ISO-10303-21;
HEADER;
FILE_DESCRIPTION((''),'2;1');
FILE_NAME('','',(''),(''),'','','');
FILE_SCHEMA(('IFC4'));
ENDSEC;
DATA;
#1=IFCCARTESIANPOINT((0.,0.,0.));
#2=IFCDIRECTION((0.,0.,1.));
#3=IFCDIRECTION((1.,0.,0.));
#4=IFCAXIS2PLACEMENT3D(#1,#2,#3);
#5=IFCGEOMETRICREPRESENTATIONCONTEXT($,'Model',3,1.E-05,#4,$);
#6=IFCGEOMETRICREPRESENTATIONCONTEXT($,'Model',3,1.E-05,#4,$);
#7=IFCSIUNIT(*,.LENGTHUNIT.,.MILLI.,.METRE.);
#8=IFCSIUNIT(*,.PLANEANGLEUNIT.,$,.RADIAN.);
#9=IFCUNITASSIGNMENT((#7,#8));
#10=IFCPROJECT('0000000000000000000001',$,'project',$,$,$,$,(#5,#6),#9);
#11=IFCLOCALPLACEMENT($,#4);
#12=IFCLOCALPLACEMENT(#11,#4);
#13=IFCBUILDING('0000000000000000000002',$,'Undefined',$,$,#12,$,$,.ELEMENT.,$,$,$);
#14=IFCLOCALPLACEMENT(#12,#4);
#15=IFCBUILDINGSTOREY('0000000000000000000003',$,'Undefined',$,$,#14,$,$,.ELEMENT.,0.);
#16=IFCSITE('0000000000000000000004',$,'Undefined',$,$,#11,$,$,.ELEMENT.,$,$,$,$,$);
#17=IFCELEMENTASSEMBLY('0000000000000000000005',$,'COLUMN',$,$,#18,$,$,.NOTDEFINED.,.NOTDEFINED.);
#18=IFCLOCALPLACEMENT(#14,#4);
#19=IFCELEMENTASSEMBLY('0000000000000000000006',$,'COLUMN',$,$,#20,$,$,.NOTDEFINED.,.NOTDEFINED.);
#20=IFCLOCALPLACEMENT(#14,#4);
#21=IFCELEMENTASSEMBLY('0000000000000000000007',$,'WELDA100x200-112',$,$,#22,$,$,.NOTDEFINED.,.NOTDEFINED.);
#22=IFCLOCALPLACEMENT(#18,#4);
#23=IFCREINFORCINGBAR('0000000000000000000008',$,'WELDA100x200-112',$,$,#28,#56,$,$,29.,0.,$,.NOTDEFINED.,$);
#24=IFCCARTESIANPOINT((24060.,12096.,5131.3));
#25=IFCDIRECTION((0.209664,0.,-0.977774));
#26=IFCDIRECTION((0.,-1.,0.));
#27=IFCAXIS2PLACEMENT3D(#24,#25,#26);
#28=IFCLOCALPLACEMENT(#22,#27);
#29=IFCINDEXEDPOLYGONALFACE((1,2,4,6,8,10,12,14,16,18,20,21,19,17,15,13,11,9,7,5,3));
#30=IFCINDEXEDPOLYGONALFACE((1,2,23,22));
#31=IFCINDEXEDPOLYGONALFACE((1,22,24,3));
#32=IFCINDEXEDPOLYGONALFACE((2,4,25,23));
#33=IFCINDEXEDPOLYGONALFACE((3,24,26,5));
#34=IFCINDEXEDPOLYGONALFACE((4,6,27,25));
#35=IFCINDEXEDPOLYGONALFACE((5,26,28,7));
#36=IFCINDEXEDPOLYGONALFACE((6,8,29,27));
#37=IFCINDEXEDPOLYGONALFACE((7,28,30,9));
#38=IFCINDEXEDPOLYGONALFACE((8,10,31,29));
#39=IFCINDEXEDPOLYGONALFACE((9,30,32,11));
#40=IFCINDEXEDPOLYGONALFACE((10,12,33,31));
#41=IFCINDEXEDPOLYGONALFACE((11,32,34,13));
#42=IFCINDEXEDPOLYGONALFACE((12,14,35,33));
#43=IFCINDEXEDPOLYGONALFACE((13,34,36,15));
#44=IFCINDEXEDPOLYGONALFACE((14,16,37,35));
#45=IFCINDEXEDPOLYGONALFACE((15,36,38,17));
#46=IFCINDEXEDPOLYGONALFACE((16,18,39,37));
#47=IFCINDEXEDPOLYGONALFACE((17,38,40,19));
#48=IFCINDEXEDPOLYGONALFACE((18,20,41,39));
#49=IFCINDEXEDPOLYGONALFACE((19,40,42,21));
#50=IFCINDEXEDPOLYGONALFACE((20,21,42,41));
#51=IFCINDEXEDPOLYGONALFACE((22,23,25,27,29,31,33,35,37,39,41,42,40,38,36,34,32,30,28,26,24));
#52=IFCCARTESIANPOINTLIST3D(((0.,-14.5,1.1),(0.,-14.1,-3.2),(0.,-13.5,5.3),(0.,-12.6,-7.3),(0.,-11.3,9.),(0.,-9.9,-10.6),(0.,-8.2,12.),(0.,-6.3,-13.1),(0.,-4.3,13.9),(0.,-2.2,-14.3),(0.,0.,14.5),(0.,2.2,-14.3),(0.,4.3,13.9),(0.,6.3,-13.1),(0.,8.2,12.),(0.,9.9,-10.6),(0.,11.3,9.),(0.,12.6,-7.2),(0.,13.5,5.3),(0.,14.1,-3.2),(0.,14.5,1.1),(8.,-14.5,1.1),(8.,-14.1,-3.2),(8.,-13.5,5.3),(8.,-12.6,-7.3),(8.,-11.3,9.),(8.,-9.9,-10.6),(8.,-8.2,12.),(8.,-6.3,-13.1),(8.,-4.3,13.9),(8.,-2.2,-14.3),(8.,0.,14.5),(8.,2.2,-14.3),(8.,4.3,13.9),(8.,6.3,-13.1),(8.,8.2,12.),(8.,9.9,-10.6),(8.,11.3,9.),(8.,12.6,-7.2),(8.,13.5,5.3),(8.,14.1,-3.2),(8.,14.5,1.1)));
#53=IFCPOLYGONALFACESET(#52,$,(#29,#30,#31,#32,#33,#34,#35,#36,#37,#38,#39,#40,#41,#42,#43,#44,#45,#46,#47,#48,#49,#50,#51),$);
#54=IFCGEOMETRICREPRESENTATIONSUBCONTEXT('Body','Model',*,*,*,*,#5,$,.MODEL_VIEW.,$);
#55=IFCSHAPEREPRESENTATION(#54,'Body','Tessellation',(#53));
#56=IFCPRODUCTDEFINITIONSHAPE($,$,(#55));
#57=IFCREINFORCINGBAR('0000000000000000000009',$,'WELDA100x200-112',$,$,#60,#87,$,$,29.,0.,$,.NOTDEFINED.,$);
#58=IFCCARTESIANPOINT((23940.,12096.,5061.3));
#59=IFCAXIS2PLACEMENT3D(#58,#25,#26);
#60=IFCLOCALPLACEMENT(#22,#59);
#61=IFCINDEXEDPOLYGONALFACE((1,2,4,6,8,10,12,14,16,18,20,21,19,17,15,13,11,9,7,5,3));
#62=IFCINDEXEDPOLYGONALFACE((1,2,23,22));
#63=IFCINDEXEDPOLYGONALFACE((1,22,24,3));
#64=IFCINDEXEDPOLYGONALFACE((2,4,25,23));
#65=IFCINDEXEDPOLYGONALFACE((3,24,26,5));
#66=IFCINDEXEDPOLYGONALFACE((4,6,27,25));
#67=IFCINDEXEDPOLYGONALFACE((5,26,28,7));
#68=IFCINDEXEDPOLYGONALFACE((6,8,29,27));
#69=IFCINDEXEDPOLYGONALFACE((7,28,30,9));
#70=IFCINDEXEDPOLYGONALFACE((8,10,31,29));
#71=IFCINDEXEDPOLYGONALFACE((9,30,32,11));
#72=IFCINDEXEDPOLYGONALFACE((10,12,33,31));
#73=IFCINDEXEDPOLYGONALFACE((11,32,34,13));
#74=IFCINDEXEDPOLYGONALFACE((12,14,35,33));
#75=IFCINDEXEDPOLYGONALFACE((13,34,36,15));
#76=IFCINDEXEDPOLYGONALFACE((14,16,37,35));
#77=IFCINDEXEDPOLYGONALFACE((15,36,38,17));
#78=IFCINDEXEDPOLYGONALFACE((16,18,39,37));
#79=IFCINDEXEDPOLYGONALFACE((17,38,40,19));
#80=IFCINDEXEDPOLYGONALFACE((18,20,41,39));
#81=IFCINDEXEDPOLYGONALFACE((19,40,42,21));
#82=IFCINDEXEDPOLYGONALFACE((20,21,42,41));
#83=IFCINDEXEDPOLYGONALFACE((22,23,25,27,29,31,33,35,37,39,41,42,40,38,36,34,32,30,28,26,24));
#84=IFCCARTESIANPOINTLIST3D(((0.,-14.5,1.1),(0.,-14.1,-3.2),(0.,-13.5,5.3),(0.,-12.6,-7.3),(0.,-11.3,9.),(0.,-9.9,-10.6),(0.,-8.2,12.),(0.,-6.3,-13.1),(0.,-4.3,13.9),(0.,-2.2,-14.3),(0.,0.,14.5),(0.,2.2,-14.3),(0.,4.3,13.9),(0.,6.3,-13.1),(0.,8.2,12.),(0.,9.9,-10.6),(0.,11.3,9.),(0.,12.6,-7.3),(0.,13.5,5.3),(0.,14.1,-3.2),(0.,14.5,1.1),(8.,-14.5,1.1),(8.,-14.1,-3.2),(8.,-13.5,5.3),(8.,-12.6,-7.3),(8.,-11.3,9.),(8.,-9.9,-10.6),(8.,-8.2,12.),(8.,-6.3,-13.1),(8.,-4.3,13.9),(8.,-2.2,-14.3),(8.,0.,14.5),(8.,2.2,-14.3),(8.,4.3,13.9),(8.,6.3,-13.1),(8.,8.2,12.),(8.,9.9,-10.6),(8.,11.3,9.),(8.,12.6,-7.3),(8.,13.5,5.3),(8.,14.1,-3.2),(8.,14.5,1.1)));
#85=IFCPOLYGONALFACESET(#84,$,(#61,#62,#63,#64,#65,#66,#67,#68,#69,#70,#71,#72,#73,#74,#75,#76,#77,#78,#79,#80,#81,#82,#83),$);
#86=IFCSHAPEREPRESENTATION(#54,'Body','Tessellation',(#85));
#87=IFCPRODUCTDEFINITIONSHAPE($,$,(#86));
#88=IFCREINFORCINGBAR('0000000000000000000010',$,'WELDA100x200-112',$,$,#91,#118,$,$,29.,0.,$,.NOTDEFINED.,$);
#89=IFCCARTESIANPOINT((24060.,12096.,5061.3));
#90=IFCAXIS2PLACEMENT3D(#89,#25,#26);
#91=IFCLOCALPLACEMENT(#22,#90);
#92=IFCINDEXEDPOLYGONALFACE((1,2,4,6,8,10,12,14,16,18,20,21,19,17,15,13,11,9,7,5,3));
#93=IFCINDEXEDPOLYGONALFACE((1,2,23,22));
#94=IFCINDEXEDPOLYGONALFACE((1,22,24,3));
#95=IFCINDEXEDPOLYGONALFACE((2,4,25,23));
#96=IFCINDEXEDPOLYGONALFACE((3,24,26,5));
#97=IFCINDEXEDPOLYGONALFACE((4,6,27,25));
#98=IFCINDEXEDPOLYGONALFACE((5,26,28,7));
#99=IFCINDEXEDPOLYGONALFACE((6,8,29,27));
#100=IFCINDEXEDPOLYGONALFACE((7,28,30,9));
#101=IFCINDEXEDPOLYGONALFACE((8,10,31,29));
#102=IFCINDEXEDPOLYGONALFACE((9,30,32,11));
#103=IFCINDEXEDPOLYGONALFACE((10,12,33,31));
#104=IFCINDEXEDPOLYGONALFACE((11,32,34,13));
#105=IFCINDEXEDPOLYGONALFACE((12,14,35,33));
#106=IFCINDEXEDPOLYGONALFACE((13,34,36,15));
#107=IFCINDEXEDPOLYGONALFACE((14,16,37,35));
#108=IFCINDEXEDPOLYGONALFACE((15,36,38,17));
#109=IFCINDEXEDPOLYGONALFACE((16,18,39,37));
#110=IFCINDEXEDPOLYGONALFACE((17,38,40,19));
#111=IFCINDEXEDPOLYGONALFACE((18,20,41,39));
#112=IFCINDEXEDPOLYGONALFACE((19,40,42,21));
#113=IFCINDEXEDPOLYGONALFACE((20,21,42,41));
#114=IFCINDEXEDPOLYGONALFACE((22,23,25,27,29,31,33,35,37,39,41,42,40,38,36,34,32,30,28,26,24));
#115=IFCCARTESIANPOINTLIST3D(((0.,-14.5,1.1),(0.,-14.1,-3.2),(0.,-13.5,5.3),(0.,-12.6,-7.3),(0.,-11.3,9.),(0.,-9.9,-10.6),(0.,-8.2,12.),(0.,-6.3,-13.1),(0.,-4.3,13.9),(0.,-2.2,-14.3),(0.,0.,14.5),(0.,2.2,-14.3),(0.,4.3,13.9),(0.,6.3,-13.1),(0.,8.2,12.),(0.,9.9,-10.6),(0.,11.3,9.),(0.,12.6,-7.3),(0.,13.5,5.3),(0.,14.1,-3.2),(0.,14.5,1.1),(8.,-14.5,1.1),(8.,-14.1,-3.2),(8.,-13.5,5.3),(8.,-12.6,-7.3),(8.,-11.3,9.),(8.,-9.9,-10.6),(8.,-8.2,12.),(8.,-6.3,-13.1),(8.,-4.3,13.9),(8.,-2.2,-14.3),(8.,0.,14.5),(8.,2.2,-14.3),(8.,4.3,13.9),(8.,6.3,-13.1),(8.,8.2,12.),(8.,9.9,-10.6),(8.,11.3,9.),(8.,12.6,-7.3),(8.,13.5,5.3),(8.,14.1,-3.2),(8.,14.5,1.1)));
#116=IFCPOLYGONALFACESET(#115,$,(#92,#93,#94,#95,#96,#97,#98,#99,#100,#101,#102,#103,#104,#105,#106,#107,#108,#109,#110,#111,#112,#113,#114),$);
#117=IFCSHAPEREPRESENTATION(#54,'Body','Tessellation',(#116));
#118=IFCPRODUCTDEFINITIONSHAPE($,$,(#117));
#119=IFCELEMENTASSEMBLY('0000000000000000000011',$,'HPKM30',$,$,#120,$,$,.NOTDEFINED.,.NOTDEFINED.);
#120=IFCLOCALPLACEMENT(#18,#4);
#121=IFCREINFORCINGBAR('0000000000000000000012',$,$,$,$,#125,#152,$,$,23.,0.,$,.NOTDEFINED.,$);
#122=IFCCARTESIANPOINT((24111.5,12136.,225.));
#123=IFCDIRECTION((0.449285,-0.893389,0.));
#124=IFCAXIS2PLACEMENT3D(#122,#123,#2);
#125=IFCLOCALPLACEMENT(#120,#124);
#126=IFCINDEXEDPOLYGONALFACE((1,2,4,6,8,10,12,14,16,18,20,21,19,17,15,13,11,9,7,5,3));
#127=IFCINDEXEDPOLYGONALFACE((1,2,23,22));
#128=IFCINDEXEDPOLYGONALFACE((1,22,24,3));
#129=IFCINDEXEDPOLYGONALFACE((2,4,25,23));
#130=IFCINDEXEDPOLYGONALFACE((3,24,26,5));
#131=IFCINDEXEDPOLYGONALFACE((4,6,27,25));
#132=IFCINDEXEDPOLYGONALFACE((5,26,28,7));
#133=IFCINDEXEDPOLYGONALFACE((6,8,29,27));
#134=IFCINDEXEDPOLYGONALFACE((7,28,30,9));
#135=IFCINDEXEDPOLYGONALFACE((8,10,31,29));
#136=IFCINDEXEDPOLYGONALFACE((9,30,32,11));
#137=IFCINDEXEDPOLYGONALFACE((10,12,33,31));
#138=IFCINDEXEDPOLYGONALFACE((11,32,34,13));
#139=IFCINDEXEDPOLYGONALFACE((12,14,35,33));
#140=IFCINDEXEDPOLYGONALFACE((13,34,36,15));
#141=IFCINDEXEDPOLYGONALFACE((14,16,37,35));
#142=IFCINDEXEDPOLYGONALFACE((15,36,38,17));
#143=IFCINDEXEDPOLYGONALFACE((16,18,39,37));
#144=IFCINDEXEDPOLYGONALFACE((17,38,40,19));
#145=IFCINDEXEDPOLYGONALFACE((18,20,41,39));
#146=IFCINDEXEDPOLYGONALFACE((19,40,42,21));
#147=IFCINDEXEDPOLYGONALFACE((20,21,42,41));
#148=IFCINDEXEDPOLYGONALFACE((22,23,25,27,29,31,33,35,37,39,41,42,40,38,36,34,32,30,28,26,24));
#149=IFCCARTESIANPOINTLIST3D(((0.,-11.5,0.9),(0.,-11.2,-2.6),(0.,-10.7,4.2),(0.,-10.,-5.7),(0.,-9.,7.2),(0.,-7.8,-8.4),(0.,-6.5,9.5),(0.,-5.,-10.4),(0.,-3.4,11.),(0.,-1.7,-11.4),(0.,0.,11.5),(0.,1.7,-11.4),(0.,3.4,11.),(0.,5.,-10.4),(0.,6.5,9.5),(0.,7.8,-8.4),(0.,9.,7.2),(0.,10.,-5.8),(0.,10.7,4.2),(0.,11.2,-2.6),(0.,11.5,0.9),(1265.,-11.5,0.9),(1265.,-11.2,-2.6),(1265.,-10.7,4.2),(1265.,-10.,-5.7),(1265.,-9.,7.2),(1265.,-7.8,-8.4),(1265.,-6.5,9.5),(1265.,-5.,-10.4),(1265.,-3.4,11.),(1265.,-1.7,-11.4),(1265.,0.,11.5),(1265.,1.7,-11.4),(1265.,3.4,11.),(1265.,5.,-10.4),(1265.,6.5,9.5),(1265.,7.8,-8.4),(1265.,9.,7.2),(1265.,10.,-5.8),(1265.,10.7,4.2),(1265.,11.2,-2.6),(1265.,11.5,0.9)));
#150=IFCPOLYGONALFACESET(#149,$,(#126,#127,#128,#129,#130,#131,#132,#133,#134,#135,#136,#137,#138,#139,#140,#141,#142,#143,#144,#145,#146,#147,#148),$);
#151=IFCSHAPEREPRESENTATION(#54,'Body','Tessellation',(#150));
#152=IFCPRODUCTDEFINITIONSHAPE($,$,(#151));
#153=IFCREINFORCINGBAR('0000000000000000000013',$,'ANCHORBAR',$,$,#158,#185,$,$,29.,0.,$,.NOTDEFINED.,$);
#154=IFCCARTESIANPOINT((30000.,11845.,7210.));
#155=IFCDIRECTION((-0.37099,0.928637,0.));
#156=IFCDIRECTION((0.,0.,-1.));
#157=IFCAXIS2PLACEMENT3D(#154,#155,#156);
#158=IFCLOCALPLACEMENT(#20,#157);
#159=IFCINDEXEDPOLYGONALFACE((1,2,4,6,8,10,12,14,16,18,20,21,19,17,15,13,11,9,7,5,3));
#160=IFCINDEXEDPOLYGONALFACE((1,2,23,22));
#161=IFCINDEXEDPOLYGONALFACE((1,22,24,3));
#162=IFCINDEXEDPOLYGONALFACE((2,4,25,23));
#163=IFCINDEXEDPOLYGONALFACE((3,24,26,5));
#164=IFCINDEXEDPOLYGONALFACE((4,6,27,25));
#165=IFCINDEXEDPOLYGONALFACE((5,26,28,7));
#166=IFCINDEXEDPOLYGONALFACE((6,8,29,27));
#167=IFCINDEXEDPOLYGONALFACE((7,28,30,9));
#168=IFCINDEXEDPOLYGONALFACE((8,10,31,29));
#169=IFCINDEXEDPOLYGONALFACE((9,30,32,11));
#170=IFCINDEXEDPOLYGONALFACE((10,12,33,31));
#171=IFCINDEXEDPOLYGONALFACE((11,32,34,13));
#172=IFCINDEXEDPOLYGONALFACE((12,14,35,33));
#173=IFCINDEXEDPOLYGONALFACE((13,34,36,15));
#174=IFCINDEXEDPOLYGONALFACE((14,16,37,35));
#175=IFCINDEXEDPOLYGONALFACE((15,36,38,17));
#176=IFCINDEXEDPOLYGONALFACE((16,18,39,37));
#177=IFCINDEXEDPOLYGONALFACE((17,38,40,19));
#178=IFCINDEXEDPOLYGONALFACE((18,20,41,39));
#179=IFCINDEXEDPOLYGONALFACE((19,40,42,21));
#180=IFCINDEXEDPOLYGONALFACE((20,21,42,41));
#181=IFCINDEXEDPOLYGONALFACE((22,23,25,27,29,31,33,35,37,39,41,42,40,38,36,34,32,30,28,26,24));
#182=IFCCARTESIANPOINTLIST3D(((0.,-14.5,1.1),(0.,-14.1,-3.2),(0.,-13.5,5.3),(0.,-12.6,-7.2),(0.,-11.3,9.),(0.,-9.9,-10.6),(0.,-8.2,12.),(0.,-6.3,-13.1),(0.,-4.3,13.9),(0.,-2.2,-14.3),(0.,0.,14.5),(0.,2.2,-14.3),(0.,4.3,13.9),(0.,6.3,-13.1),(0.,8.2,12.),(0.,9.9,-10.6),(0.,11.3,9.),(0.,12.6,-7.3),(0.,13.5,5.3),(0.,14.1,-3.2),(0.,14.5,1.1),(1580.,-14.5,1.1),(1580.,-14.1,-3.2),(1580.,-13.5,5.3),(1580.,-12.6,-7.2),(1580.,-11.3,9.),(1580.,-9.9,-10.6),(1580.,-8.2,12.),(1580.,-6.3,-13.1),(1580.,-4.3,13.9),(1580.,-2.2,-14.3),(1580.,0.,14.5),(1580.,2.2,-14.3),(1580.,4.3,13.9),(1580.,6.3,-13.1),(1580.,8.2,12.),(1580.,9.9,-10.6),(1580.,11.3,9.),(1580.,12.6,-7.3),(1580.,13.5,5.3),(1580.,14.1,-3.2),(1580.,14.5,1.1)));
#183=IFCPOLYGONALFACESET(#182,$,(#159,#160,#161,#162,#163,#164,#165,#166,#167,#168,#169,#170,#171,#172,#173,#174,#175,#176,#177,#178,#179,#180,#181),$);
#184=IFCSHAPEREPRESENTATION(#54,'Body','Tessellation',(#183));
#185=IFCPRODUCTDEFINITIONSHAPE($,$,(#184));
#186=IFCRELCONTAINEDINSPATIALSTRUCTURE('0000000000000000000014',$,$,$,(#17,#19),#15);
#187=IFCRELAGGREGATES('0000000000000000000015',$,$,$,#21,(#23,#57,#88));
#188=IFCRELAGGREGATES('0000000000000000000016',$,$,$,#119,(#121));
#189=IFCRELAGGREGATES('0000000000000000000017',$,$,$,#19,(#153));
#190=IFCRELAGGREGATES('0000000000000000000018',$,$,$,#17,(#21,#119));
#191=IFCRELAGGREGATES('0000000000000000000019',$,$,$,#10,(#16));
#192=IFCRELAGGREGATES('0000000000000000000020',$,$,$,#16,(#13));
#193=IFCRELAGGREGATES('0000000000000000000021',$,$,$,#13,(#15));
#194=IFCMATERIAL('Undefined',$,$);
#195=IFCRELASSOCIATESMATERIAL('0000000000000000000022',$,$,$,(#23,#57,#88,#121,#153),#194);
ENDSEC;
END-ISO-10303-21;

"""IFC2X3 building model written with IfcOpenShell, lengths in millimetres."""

from ifc_helpers import new_model, entity, si_unit, frame, origin_with_axes, place, context, subcontext, project, spatial, source, transform, mapped, material, element, aggregate, save


model = new_model("IFC2X3")

# Units and contexts
model_context_1 = context("Model", 3, precision=1e-05, world=origin_with_axes())
model_context_2 = context("Model", 3, precision=1e-05, world=origin_with_axes())
body_context = subcontext(model_context_1, "Body", "Model", "MODEL_VIEW")
ifc_project = project(units=[si_unit("LENGTHUNIT", "METRE", prefix="MILLI"), si_unit("PLANEANGLEUNIT", "RADIAN")], contexts=[model_context_1, model_context_2])

# Site, building, storey
site_placement = place(None, origin_with_axes())
site = spatial("IfcSite", under=ifc_project, at=site_placement, Name="Undefined", CompositionType="ELEMENT")
building_placement = place(site_placement, origin_with_axes())
building = spatial("IfcBuilding", under=site, at=building_placement, Name="Undefined", CompositionType="ELEMENT")
storey_placement = place(building_placement, origin_with_axes())
storey = spatial("IfcBuildingStorey", under=building, at=storey_placement, Name="Undefined", CompositionType="ELEMENT", Elevation=0.0)

# Element assemblies
assembly_1_placement = place(storey_placement, origin_with_axes())
assembly_1 = element("IfcElementAssembly", 1, at=assembly_1_placement, inside=storey, Name="COLUMN", AssemblyPlace="NOTDEFINED", PredefinedType="NOTDEFINED")
assembly_2_placement = place(storey_placement, origin_with_axes())
assembly_2 = element("IfcElementAssembly", 2, at=assembly_2_placement, inside=storey, Name="COLUMN", AssemblyPlace="NOTDEFINED", PredefinedType="NOTDEFINED")

# Element assembly
assembly_3_placement = place(assembly_1_placement, origin_with_axes())
assembly_3 = element("IfcElementAssembly", 3, at=assembly_3_placement, Name="WELDA100x200-112", AssemblyPlace="NOTDEFINED", PredefinedType="NOTDEFINED")

# Reinforcing bars
ifc_material_1 = material(Name="Undefined")
shared_shape_1 = source(origin_with_axes(), body_context, "Body", "AdvancedSweptSolid", [
    entity("IfcSweptDiskSolid", entity("IfcTrimmedCurve", entity("IfcLine", entity("IfcCartesianPoint", [0.0, 0.0, 0.0]), entity("IfcVector", entity("IfcDirection", [1.0, 0.0, 0.0]), 1.0)), [entity("IfcParameterValue", 0.0)], [entity("IfcParameterValue", 8.0)], True, "PARAMETER"), 14.5, None, 0.0, 8.0),
])
reinforcing_bar_1_placement = place(assembly_3_placement, frame((24060.0, 12096.0, 5131.3), z_axis=(0.209664, 0.0, -0.977774), x_axis=(0.0, -1.0, 0.0)))
reinforcing_bar_1 = element("IfcReinforcingBar", 4, at=reinforcing_bar_1_placement, material=ifc_material_1, Name="WELDA100x200-112", BarRole="NOTDEFINED", CrossSectionArea=0.0, NominalDiameter=29.0, context=body_context, shape_type="MappedRepresentation", body=[
    mapped(shared_shape_1, transform((0.0, 0.0, 0.0))),
])
shared_shape_2 = source(origin_with_axes(), body_context, "Body", "AdvancedSweptSolid", [
    entity("IfcSweptDiskSolid", entity("IfcTrimmedCurve", entity("IfcLine", entity("IfcCartesianPoint", [0.0, 0.0, 0.0]), entity("IfcVector", entity("IfcDirection", [1.0, 0.0, 0.0]), 1.0)), [entity("IfcParameterValue", 0.0)], [entity("IfcParameterValue", 8.0)], True, "PARAMETER"), 14.5, None, 0.0, 8.0),
])
reinforcing_bar_2_placement = place(assembly_3_placement, frame((23940.0, 12096.0, 5061.3), z_axis=(0.209664, 0.0, -0.977774), x_axis=(0.0, -1.0, 0.0)))
reinforcing_bar_2 = element("IfcReinforcingBar", 5, at=reinforcing_bar_2_placement, material=ifc_material_1, Name="WELDA100x200-112", BarRole="NOTDEFINED", CrossSectionArea=0.0, NominalDiameter=29.0, context=body_context, shape_type="MappedRepresentation", body=[
    mapped(shared_shape_2, transform((0.0, 0.0, 0.0))),
])
shared_shape_3 = source(origin_with_axes(), body_context, "Body", "AdvancedSweptSolid", [
    entity("IfcSweptDiskSolid", entity("IfcTrimmedCurve", entity("IfcLine", entity("IfcCartesianPoint", [0.0, 0.0, 0.0]), entity("IfcVector", entity("IfcDirection", [1.0, 0.0, 0.0]), 1.0)), [entity("IfcParameterValue", 0.0)], [entity("IfcParameterValue", 8.0)], True, "PARAMETER"), 14.5, None, 0.0, 8.0),
])
reinforcing_bar_3_placement = place(assembly_3_placement, frame((24060.0, 12096.0, 5061.3), z_axis=(0.209664, 0.0, -0.977774), x_axis=(0.0, -1.0, 0.0)))
reinforcing_bar_3 = element("IfcReinforcingBar", 6, at=reinforcing_bar_3_placement, material=ifc_material_1, Name="WELDA100x200-112", BarRole="NOTDEFINED", CrossSectionArea=0.0, NominalDiameter=29.0, context=body_context, shape_type="MappedRepresentation", body=[
    mapped(shared_shape_3, transform((0.0, 0.0, 0.0))),
])
aggregate(assembly_3, [reinforcing_bar_1, reinforcing_bar_2, reinforcing_bar_3])

# Element assembly, reinforcing bar
assembly_4_placement = place(assembly_1_placement, origin_with_axes())
assembly_4 = element("IfcElementAssembly", 7, at=assembly_4_placement, Name="HPKM30", AssemblyPlace="NOTDEFINED", PredefinedType="NOTDEFINED")
shared_shape_4 = source(origin_with_axes(), body_context, "Body", "AdvancedSweptSolid", [
    entity("IfcSweptDiskSolid", entity("IfcTrimmedCurve", entity("IfcLine", entity("IfcCartesianPoint", [0.0, 0.0, 0.0]), entity("IfcVector", entity("IfcDirection", [1.0, 0.0, 0.0]), 1.0)), [entity("IfcParameterValue", 0.0)], [entity("IfcParameterValue", 1265.0)], True, "PARAMETER"), 11.5, None, 0.0, 1265.0),
])
reinforcing_bar_4_placement = place(assembly_4_placement, frame((24111.5, 12136.0, 225.0), z_axis=(0.449285, -0.893389, 0.0), x_axis=(0.0, 0.0, 1.0)))
reinforcing_bar_4 = element("IfcReinforcingBar", 8, at=reinforcing_bar_4_placement, material=ifc_material_1, BarRole="NOTDEFINED", CrossSectionArea=0.0, NominalDiameter=23.0, context=body_context, shape_type="MappedRepresentation", body=[
    mapped(shared_shape_4, transform((0.0, 0.0, 0.0))),
])
aggregate(assembly_4, [reinforcing_bar_4])

# Reinforcing bar
shared_shape_5 = source(origin_with_axes(), body_context, "Body", "AdvancedSweptSolid", [
    entity("IfcSweptDiskSolid", entity("IfcTrimmedCurve", entity("IfcLine", entity("IfcCartesianPoint", [0.0, 0.0, 0.0]), entity("IfcVector", entity("IfcDirection", [1.0, 0.0, 0.0]), 1.0)), [entity("IfcParameterValue", 0.0)], [entity("IfcParameterValue", 1580.0)], True, "PARAMETER"), 14.5, None, 0.0, 1580.0),
])
reinforcing_bar_5_placement = place(assembly_2_placement, frame((30000.0, 11845.0, 7210.0), z_axis=(-0.37099, 0.928637, 0.0), x_axis=(0.0, 0.0, -1.0)))
reinforcing_bar_5 = element("IfcReinforcingBar", 9, at=reinforcing_bar_5_placement, material=ifc_material_1, Name="ANCHORBAR", BarRole="NOTDEFINED", CrossSectionArea=0.0, NominalDiameter=29.0, context=body_context, shape_type="MappedRepresentation", body=[
    mapped(shared_shape_5, transform((0.0, 0.0, 0.0))),
])
aggregate(assembly_2, [reinforcing_bar_5])
aggregate(assembly_1, [assembly_3, assembly_4])

save(model, "model.ifc")
